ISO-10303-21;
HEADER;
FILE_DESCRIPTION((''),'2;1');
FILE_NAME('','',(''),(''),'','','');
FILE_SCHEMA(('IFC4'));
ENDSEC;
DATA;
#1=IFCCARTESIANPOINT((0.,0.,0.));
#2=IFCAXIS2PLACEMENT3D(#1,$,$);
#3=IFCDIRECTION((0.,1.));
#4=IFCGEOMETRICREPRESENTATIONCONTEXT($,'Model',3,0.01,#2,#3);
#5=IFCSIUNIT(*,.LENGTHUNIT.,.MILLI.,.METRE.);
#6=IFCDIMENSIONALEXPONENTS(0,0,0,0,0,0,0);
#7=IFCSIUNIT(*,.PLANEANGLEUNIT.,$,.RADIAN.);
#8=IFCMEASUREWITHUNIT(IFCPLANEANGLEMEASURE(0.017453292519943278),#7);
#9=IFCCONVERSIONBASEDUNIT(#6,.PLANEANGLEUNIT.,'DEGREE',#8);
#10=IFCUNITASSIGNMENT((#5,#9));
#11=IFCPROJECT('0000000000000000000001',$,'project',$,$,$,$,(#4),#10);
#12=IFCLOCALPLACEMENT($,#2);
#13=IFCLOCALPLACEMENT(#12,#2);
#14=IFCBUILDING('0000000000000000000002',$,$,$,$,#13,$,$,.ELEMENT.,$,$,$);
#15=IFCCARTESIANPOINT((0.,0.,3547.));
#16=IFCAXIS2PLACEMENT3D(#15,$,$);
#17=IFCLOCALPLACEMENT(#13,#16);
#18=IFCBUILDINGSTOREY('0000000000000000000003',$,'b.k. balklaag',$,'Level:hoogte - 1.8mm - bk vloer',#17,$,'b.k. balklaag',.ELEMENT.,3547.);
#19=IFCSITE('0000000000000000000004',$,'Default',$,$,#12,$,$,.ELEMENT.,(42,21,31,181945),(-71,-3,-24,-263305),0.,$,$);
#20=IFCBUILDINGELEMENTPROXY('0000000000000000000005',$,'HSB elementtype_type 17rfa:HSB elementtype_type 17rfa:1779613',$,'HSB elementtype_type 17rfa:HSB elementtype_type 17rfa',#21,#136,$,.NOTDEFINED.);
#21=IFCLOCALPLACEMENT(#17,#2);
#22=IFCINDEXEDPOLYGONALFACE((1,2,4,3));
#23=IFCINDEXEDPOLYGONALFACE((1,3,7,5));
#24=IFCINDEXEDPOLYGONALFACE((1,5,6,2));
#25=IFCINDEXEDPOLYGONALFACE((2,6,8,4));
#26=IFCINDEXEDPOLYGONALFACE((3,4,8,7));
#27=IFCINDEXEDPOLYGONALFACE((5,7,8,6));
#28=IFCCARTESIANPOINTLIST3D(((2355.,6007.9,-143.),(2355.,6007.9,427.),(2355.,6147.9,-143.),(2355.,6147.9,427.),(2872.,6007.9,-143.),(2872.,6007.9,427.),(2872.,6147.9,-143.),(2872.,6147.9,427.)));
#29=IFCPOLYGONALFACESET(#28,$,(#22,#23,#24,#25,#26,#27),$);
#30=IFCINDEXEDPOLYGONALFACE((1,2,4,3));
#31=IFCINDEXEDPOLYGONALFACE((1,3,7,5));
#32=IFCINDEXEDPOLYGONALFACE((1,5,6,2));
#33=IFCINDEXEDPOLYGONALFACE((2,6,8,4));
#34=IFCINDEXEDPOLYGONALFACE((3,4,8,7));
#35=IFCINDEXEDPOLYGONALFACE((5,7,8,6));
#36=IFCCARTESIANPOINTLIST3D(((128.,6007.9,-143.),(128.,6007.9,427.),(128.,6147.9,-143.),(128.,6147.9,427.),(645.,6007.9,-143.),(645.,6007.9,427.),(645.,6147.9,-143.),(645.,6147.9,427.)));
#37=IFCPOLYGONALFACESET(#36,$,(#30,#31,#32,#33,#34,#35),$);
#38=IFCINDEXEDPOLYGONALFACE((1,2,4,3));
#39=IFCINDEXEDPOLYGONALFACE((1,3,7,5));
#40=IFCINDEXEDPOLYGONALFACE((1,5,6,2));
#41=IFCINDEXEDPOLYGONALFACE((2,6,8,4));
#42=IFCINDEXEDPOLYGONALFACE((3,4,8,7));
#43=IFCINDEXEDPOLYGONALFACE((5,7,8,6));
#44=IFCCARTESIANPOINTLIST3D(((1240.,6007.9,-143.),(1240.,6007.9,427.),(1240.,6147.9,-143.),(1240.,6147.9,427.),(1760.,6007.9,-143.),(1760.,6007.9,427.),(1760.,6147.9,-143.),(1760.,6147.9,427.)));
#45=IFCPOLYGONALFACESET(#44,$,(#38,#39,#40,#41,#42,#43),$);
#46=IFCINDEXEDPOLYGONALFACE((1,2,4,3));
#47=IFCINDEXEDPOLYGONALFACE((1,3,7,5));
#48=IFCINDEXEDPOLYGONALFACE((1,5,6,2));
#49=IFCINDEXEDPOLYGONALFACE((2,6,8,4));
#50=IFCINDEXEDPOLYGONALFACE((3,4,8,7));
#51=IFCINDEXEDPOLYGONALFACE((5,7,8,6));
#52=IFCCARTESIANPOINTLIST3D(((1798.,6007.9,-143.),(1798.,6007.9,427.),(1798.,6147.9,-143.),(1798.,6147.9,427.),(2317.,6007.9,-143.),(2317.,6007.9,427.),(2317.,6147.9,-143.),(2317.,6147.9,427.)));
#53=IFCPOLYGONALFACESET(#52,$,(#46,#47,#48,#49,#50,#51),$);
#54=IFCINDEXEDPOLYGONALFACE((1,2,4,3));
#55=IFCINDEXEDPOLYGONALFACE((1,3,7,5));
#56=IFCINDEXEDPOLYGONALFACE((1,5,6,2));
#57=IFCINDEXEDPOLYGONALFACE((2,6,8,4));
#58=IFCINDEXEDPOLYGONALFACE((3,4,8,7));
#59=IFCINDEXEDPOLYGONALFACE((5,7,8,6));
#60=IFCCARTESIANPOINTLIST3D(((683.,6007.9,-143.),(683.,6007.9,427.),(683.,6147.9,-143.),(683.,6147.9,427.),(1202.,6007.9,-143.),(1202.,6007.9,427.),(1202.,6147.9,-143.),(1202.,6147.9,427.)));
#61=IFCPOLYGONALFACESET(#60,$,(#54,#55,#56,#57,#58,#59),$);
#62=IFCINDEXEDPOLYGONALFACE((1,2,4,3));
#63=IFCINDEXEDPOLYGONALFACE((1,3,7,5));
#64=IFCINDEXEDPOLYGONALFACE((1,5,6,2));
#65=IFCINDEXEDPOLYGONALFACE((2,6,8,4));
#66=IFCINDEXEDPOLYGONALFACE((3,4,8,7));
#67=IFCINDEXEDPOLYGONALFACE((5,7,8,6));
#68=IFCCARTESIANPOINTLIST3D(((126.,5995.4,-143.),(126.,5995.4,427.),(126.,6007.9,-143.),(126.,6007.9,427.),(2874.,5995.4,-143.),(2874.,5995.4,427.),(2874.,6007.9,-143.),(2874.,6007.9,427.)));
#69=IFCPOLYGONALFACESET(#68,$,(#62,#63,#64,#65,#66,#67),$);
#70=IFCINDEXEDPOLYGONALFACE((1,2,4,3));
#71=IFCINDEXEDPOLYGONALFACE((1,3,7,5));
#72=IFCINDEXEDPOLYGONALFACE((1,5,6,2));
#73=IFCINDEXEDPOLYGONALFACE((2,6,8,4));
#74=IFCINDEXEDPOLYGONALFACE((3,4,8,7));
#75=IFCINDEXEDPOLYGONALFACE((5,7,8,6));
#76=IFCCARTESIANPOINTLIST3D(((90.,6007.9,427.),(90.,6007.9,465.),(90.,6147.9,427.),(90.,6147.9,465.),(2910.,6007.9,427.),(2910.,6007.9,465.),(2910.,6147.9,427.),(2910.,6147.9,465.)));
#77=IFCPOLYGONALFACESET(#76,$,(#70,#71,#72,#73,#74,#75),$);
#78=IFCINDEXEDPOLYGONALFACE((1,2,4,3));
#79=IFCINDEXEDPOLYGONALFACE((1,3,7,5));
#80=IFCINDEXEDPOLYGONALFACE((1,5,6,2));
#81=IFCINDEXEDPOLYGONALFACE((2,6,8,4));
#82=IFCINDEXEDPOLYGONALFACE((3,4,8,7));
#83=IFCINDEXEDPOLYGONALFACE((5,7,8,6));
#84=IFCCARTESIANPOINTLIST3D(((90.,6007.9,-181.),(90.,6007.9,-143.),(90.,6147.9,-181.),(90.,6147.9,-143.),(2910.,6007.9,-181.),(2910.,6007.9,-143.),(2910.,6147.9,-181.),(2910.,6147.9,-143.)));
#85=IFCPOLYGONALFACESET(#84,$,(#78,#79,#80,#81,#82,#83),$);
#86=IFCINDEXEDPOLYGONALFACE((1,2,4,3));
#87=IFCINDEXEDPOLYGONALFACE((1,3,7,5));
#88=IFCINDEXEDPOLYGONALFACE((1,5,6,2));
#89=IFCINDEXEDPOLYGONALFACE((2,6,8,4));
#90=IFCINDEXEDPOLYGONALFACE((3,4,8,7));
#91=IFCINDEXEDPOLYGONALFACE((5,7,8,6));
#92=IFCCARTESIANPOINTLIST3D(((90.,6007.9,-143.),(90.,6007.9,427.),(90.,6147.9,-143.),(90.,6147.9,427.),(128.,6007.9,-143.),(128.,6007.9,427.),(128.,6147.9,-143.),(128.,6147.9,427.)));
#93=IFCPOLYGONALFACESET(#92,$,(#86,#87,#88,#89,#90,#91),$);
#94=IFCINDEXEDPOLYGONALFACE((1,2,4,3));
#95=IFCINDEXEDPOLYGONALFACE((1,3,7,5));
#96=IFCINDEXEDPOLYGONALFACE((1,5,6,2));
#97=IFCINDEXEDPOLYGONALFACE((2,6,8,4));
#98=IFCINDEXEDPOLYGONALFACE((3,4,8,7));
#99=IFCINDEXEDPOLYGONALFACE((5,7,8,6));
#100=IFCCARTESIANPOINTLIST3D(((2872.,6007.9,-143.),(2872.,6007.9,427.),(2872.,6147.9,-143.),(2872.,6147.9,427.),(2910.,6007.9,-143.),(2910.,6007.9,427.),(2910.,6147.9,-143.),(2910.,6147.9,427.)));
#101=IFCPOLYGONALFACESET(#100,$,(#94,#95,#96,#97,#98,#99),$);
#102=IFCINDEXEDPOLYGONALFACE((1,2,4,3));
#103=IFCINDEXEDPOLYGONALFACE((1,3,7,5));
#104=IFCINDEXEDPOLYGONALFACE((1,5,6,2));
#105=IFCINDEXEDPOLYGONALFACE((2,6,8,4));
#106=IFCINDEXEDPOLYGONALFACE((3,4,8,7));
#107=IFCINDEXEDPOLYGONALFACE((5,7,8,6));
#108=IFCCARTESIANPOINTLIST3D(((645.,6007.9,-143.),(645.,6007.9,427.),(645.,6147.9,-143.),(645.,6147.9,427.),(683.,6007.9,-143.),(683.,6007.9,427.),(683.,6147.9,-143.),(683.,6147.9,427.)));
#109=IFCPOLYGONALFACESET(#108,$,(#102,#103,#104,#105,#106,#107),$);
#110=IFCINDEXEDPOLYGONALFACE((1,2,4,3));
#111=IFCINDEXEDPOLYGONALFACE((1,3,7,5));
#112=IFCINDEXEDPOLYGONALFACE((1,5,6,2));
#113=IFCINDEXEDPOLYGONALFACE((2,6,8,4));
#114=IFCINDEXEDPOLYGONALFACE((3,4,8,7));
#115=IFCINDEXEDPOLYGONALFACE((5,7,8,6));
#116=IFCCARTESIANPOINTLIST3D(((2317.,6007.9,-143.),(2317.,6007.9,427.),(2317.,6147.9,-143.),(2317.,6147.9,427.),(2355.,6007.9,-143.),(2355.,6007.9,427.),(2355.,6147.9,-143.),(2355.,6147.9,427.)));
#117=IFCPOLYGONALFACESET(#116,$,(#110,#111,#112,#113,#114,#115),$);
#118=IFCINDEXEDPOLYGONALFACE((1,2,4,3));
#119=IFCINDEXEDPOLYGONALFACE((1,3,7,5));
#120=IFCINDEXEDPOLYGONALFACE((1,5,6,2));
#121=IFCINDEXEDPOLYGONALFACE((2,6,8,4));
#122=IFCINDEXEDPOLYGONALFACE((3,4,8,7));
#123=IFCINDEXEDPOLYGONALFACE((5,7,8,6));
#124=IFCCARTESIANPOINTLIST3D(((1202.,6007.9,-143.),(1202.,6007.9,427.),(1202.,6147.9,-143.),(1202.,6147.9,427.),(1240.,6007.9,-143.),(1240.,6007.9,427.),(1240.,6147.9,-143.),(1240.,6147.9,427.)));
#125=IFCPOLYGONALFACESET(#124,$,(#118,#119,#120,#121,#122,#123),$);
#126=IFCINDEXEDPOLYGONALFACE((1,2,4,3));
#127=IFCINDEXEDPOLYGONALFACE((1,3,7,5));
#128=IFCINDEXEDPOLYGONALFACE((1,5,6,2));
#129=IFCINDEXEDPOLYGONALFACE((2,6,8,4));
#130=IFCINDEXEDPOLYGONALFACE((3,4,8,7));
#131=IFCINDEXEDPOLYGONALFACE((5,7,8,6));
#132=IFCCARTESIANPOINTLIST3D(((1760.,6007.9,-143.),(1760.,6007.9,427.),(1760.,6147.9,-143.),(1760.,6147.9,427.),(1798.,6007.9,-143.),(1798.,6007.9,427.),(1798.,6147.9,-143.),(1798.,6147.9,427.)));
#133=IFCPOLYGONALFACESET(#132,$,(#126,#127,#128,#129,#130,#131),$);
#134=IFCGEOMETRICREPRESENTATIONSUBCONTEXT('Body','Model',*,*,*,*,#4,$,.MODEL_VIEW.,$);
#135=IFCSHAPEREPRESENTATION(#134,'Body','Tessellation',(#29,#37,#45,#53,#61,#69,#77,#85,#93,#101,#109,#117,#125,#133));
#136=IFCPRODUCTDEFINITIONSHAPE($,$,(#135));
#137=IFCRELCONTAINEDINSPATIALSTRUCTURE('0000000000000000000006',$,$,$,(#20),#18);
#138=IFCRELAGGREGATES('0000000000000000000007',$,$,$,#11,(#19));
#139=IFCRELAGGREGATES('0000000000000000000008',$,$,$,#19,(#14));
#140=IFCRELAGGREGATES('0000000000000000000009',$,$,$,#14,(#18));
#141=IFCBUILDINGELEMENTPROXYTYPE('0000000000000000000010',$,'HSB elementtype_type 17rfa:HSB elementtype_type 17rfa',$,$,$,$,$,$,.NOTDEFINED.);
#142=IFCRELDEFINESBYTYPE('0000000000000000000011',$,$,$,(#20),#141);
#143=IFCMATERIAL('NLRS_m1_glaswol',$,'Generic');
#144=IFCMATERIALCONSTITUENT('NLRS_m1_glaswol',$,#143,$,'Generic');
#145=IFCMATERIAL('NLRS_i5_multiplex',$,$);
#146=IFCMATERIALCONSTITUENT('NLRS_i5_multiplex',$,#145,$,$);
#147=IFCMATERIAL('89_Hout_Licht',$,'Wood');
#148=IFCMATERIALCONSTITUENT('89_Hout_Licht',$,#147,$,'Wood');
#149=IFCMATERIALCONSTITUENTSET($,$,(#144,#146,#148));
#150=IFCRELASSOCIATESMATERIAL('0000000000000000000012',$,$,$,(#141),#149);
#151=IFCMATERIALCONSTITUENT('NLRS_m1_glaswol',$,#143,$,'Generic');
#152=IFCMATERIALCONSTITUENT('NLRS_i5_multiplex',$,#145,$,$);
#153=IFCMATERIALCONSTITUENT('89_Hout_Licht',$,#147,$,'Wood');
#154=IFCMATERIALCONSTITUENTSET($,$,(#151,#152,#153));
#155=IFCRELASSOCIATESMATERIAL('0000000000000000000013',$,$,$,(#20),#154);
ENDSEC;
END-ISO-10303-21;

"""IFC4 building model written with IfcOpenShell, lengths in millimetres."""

from ifc_helpers import new_model, entity, si_unit, converted_unit, direction, frame, origin, place, context, subcontext, project, spatial, indexed_curve, outline, extrude, source, transform, mapped, material, constituent, constituent_set, type_object, type_shapes, element, save


model = new_model("IFC4")

# Units and contexts
model_context = context("Model", 3, precision=0.01, world=origin(), true_north=direction((0.0, 1.0)))
body_context = subcontext(model_context, "Body", "Model", "MODEL_VIEW")
ifc_project = project(units=[si_unit("LENGTHUNIT", "METRE", prefix="MILLI"), converted_unit("PLANEANGLEUNIT", "DEGREE", entity("IfcPlaneAngleMeasure", 0.017453292519943278), si_unit("PLANEANGLEUNIT", "RADIAN"), dimensions=[0, 0, 0, 0, 0, 0, 0])], contexts=[model_context])

# Site, building, storey
site_placement = place(None, origin())
site = spatial("IfcSite", under=ifc_project, at=site_placement, Name="Default", CompositionType="ELEMENT", RefLatitude=(42, 21, 31, 181945), RefLongitude=(-71, -3, -24, -263305), RefElevation=0.0)
building_placement = place(site_placement, origin())
building = spatial("IfcBuilding", under=site, at=building_placement, CompositionType="ELEMENT")
storey_placement = place(building_placement, frame((0.0, 0.0, 3547.0)))
storey = spatial("IfcBuildingStorey", under=building, at=storey_placement, Name="b.k. balklaag", ObjectType="Level:hoogte - 1.8mm - bk vloer", LongName="b.k. balklaag", CompositionType="ELEMENT", Elevation=3547.0)

# Shared definitions
ifc_material_1 = material(Name="89_Hout_Licht", Category="Wood")

# Building element proxy
ifc_material_2 = material(Name="NLRS_m1_glaswol", Category="Generic")
ifc_constituent_1 = constituent(ifc_material_2, Name="NLRS_m1_glaswol", Category="Generic")
ifc_material_3 = material(Name="NLRS_i5_multiplex")
ifc_constituent_2 = constituent(ifc_material_3, Name="NLRS_i5_multiplex")
ifc_constituent_3 = constituent(ifc_material_1, Name="89_Hout_Licht", Category="Wood")
ifc_constituent_set_1 = constituent_set(constituents=[ifc_constituent_1, ifc_constituent_2, ifc_constituent_3])
ifc_constituent_4 = constituent(ifc_material_2, Name="NLRS_m1_glaswol", Category="Generic")
ifc_constituent_5 = constituent(ifc_material_3, Name="NLRS_i5_multiplex")
ifc_constituent_6 = constituent(ifc_material_1, Name="89_Hout_Licht", Category="Wood")
ifc_constituent_set_2 = constituent_set(constituents=[ifc_constituent_4, ifc_constituent_5, ifc_constituent_6])
building_element_proxy_type_1 = type_object("IfcBuildingElementProxyType", Name="HSB elementtype_type 17rfa:HSB elementtype_type 17rfa", PredefinedType="NOTDEFINED", material=ifc_constituent_set_2)
shared_shape_1 = source(origin(), body_context, "Body", "SweptSolid", [
    extrude(outline(indexed_curve([(-70.0, -258.5), (70.0, -258.5), (70.0, 258.5), (-70.0, 258.5), (-70.0, -258.5)], self_intersect=False)), frame((-1149.5, -70.0, 38.0), z_axis=(0.0, 0.0, 1.0), x_axis=(0.0, 1.0, 0.0)), (0.0, 0.0, 1.0), 570.0),
    extrude(outline(indexed_curve([(-70.0, -258.5), (70.0, -258.5), (70.0, 258.5), (-70.0, 258.5), (-70.0, -258.5)], self_intersect=False)), frame((1077.5, -70.0, 38.0), z_axis=(0.0, 0.0, 1.0), x_axis=(0.0, 1.0, 0.0)), (0.0, 0.0, 1.0), 570.0),
    extrude(outline(indexed_curve([(-70.0, -260.0), (70.0, -260.0), (70.0, 260.0), (-70.0, 260.0), (-70.0, -260.0)], self_intersect=False)), frame((-36.0, -70.0, 38.0), z_axis=(0.0, 0.0, 1.0), x_axis=(0.0, 1.0, 0.0)), (0.0, 0.0, 1.0), 570.0),
    extrude(outline(indexed_curve([(-70.0, -259.5), (70.0, -259.5), (70.0, 259.5), (-70.0, 259.5), (-70.0, -259.5)], self_intersect=False)), frame((-593.5, -70.0, 38.0), z_axis=(0.0, 0.0, 1.0), x_axis=(0.0, 1.0, 0.0)), (0.0, 0.0, 1.0), 570.0),
    extrude(outline(indexed_curve([(-70.0, -259.5), (70.0, -259.5), (70.0, 259.5), (-70.0, 259.5), (-70.0, -259.5)], self_intersect=False)), frame((521.5, -70.0, 38.0), z_axis=(0.0, 0.0, 1.0), x_axis=(0.0, 1.0, 0.0)), (0.0, 0.0, 1.0), 570.0),
    extrude(outline(indexed_curve([(-6.2, -1374.0), (6.2, -1374.0), (6.2, 1374.0), (-6.2, 1374.0), (-6.2, -1374.0)], self_intersect=False)), frame((-36.0, 6.2, 38.0), z_axis=(0.0, 0.0, 1.0), x_axis=(0.0, 1.0, 0.0)), (0.0, 0.0, 1.0), 570.0),
    extrude(outline(indexed_curve([(-70.0, -1410.0), (70.0, -1410.0), (70.0, 1410.0), (-70.0, 1410.0), (-70.0, -1410.0)], self_intersect=False)), frame((-36.0, -70.0, 608.0), z_axis=(0.0, 0.0, 1.0), x_axis=(0.0, 1.0, 0.0)), (0.0, 0.0, 1.0), 38.0),
    extrude(outline(indexed_curve([(-70.0, -1410.0), (70.0, -1410.0), (70.0, 1410.0), (-70.0, 1410.0), (-70.0, -1410.0)], self_intersect=False)), frame((-36.0, -70.0, 0.0), z_axis=(0.0, 0.0, 1.0), x_axis=(0.0, 1.0, 0.0)), (0.0, 0.0, 1.0), 38.0),
    extrude(outline(indexed_curve([(-70.0, -19.0), (70.0, -19.0), (70.0, 19.0), (-70.0, 19.0), (-70.0, -19.0)], self_intersect=False)), frame((1355.0, -70.0, 38.0), z_axis=(0.0, 0.0, 1.0), x_axis=(0.0, 1.0, 0.0)), (0.0, 0.0, 1.0), 570.0),
    extrude(outline(indexed_curve([(-70.0, -19.0), (70.0, -19.0), (70.0, 19.0), (-70.0, 19.0), (-70.0, -19.0)], self_intersect=False)), frame((-1427.0, -70.0, 38.0), z_axis=(0.0, 0.0, 1.0), x_axis=(0.0, 1.0, 0.0)), (0.0, 0.0, 1.0), 570.0),
    extrude(outline(indexed_curve([(-70.0, -19.0), (70.0, -19.0), (70.0, 19.0), (-70.0, 19.0), (-70.0, -19.0)], self_intersect=False)), frame((800.0, -70.0, 38.0), z_axis=(0.0, 0.0, 1.0), x_axis=(0.0, 1.0, 0.0)), (0.0, 0.0, 1.0), 570.0),
    extrude(outline(indexed_curve([(-70.0, -19.0), (70.0, -19.0), (70.0, 19.0), (-70.0, 19.0), (-70.0, -19.0)], self_intersect=False)), frame((-872.0, -70.0, 38.0), z_axis=(0.0, 0.0, 1.0), x_axis=(0.0, 1.0, 0.0)), (0.0, 0.0, 1.0), 570.0),
    extrude(outline(indexed_curve([(-70.0, -19.0), (70.0, -19.0), (70.0, 19.0), (-70.0, 19.0), (-70.0, -19.0)], self_intersect=False)), frame((243.0, -70.0, 38.0), z_axis=(0.0, 0.0, 1.0), x_axis=(0.0, 1.0, 0.0)), (0.0, 0.0, 1.0), 570.0),
    extrude(outline(indexed_curve([(-70.0, -19.0), (70.0, -19.0), (70.0, 19.0), (-70.0, 19.0), (-70.0, -19.0)], self_intersect=False)), frame((-315.0, -70.0, 38.0), z_axis=(0.0, 0.0, 1.0), x_axis=(0.0, 1.0, 0.0)), (0.0, 0.0, 1.0), 570.0),
])
type_shapes(building_element_proxy_type_1, [shared_shape_1])
proxy_1_placement = place(storey_placement, frame((1464.0, 6007.9, -181.0), z_axis=(0.0, 0.0, 1.0), x_axis=(-1.0, 0.0, 0.0)))
element("IfcBuildingElementProxy", 1, at=proxy_1_placement, inside=storey, type_object=building_element_proxy_type_1, material=ifc_constituent_set_1, Name="HSB elementtype_type 17rfa:HSB elementtype_type 17rfa:1779613", ObjectType="HSB elementtype_type 17rfa:HSB elementtype_type 17rfa", PredefinedType="NOTDEFINED", context=body_context, shape_type="MappedRepresentation", body=[
    mapped(shared_shape_1, transform((0.0, 0.0, 0.0), scale=1.0)),
])

save(model, "model.ifc")
